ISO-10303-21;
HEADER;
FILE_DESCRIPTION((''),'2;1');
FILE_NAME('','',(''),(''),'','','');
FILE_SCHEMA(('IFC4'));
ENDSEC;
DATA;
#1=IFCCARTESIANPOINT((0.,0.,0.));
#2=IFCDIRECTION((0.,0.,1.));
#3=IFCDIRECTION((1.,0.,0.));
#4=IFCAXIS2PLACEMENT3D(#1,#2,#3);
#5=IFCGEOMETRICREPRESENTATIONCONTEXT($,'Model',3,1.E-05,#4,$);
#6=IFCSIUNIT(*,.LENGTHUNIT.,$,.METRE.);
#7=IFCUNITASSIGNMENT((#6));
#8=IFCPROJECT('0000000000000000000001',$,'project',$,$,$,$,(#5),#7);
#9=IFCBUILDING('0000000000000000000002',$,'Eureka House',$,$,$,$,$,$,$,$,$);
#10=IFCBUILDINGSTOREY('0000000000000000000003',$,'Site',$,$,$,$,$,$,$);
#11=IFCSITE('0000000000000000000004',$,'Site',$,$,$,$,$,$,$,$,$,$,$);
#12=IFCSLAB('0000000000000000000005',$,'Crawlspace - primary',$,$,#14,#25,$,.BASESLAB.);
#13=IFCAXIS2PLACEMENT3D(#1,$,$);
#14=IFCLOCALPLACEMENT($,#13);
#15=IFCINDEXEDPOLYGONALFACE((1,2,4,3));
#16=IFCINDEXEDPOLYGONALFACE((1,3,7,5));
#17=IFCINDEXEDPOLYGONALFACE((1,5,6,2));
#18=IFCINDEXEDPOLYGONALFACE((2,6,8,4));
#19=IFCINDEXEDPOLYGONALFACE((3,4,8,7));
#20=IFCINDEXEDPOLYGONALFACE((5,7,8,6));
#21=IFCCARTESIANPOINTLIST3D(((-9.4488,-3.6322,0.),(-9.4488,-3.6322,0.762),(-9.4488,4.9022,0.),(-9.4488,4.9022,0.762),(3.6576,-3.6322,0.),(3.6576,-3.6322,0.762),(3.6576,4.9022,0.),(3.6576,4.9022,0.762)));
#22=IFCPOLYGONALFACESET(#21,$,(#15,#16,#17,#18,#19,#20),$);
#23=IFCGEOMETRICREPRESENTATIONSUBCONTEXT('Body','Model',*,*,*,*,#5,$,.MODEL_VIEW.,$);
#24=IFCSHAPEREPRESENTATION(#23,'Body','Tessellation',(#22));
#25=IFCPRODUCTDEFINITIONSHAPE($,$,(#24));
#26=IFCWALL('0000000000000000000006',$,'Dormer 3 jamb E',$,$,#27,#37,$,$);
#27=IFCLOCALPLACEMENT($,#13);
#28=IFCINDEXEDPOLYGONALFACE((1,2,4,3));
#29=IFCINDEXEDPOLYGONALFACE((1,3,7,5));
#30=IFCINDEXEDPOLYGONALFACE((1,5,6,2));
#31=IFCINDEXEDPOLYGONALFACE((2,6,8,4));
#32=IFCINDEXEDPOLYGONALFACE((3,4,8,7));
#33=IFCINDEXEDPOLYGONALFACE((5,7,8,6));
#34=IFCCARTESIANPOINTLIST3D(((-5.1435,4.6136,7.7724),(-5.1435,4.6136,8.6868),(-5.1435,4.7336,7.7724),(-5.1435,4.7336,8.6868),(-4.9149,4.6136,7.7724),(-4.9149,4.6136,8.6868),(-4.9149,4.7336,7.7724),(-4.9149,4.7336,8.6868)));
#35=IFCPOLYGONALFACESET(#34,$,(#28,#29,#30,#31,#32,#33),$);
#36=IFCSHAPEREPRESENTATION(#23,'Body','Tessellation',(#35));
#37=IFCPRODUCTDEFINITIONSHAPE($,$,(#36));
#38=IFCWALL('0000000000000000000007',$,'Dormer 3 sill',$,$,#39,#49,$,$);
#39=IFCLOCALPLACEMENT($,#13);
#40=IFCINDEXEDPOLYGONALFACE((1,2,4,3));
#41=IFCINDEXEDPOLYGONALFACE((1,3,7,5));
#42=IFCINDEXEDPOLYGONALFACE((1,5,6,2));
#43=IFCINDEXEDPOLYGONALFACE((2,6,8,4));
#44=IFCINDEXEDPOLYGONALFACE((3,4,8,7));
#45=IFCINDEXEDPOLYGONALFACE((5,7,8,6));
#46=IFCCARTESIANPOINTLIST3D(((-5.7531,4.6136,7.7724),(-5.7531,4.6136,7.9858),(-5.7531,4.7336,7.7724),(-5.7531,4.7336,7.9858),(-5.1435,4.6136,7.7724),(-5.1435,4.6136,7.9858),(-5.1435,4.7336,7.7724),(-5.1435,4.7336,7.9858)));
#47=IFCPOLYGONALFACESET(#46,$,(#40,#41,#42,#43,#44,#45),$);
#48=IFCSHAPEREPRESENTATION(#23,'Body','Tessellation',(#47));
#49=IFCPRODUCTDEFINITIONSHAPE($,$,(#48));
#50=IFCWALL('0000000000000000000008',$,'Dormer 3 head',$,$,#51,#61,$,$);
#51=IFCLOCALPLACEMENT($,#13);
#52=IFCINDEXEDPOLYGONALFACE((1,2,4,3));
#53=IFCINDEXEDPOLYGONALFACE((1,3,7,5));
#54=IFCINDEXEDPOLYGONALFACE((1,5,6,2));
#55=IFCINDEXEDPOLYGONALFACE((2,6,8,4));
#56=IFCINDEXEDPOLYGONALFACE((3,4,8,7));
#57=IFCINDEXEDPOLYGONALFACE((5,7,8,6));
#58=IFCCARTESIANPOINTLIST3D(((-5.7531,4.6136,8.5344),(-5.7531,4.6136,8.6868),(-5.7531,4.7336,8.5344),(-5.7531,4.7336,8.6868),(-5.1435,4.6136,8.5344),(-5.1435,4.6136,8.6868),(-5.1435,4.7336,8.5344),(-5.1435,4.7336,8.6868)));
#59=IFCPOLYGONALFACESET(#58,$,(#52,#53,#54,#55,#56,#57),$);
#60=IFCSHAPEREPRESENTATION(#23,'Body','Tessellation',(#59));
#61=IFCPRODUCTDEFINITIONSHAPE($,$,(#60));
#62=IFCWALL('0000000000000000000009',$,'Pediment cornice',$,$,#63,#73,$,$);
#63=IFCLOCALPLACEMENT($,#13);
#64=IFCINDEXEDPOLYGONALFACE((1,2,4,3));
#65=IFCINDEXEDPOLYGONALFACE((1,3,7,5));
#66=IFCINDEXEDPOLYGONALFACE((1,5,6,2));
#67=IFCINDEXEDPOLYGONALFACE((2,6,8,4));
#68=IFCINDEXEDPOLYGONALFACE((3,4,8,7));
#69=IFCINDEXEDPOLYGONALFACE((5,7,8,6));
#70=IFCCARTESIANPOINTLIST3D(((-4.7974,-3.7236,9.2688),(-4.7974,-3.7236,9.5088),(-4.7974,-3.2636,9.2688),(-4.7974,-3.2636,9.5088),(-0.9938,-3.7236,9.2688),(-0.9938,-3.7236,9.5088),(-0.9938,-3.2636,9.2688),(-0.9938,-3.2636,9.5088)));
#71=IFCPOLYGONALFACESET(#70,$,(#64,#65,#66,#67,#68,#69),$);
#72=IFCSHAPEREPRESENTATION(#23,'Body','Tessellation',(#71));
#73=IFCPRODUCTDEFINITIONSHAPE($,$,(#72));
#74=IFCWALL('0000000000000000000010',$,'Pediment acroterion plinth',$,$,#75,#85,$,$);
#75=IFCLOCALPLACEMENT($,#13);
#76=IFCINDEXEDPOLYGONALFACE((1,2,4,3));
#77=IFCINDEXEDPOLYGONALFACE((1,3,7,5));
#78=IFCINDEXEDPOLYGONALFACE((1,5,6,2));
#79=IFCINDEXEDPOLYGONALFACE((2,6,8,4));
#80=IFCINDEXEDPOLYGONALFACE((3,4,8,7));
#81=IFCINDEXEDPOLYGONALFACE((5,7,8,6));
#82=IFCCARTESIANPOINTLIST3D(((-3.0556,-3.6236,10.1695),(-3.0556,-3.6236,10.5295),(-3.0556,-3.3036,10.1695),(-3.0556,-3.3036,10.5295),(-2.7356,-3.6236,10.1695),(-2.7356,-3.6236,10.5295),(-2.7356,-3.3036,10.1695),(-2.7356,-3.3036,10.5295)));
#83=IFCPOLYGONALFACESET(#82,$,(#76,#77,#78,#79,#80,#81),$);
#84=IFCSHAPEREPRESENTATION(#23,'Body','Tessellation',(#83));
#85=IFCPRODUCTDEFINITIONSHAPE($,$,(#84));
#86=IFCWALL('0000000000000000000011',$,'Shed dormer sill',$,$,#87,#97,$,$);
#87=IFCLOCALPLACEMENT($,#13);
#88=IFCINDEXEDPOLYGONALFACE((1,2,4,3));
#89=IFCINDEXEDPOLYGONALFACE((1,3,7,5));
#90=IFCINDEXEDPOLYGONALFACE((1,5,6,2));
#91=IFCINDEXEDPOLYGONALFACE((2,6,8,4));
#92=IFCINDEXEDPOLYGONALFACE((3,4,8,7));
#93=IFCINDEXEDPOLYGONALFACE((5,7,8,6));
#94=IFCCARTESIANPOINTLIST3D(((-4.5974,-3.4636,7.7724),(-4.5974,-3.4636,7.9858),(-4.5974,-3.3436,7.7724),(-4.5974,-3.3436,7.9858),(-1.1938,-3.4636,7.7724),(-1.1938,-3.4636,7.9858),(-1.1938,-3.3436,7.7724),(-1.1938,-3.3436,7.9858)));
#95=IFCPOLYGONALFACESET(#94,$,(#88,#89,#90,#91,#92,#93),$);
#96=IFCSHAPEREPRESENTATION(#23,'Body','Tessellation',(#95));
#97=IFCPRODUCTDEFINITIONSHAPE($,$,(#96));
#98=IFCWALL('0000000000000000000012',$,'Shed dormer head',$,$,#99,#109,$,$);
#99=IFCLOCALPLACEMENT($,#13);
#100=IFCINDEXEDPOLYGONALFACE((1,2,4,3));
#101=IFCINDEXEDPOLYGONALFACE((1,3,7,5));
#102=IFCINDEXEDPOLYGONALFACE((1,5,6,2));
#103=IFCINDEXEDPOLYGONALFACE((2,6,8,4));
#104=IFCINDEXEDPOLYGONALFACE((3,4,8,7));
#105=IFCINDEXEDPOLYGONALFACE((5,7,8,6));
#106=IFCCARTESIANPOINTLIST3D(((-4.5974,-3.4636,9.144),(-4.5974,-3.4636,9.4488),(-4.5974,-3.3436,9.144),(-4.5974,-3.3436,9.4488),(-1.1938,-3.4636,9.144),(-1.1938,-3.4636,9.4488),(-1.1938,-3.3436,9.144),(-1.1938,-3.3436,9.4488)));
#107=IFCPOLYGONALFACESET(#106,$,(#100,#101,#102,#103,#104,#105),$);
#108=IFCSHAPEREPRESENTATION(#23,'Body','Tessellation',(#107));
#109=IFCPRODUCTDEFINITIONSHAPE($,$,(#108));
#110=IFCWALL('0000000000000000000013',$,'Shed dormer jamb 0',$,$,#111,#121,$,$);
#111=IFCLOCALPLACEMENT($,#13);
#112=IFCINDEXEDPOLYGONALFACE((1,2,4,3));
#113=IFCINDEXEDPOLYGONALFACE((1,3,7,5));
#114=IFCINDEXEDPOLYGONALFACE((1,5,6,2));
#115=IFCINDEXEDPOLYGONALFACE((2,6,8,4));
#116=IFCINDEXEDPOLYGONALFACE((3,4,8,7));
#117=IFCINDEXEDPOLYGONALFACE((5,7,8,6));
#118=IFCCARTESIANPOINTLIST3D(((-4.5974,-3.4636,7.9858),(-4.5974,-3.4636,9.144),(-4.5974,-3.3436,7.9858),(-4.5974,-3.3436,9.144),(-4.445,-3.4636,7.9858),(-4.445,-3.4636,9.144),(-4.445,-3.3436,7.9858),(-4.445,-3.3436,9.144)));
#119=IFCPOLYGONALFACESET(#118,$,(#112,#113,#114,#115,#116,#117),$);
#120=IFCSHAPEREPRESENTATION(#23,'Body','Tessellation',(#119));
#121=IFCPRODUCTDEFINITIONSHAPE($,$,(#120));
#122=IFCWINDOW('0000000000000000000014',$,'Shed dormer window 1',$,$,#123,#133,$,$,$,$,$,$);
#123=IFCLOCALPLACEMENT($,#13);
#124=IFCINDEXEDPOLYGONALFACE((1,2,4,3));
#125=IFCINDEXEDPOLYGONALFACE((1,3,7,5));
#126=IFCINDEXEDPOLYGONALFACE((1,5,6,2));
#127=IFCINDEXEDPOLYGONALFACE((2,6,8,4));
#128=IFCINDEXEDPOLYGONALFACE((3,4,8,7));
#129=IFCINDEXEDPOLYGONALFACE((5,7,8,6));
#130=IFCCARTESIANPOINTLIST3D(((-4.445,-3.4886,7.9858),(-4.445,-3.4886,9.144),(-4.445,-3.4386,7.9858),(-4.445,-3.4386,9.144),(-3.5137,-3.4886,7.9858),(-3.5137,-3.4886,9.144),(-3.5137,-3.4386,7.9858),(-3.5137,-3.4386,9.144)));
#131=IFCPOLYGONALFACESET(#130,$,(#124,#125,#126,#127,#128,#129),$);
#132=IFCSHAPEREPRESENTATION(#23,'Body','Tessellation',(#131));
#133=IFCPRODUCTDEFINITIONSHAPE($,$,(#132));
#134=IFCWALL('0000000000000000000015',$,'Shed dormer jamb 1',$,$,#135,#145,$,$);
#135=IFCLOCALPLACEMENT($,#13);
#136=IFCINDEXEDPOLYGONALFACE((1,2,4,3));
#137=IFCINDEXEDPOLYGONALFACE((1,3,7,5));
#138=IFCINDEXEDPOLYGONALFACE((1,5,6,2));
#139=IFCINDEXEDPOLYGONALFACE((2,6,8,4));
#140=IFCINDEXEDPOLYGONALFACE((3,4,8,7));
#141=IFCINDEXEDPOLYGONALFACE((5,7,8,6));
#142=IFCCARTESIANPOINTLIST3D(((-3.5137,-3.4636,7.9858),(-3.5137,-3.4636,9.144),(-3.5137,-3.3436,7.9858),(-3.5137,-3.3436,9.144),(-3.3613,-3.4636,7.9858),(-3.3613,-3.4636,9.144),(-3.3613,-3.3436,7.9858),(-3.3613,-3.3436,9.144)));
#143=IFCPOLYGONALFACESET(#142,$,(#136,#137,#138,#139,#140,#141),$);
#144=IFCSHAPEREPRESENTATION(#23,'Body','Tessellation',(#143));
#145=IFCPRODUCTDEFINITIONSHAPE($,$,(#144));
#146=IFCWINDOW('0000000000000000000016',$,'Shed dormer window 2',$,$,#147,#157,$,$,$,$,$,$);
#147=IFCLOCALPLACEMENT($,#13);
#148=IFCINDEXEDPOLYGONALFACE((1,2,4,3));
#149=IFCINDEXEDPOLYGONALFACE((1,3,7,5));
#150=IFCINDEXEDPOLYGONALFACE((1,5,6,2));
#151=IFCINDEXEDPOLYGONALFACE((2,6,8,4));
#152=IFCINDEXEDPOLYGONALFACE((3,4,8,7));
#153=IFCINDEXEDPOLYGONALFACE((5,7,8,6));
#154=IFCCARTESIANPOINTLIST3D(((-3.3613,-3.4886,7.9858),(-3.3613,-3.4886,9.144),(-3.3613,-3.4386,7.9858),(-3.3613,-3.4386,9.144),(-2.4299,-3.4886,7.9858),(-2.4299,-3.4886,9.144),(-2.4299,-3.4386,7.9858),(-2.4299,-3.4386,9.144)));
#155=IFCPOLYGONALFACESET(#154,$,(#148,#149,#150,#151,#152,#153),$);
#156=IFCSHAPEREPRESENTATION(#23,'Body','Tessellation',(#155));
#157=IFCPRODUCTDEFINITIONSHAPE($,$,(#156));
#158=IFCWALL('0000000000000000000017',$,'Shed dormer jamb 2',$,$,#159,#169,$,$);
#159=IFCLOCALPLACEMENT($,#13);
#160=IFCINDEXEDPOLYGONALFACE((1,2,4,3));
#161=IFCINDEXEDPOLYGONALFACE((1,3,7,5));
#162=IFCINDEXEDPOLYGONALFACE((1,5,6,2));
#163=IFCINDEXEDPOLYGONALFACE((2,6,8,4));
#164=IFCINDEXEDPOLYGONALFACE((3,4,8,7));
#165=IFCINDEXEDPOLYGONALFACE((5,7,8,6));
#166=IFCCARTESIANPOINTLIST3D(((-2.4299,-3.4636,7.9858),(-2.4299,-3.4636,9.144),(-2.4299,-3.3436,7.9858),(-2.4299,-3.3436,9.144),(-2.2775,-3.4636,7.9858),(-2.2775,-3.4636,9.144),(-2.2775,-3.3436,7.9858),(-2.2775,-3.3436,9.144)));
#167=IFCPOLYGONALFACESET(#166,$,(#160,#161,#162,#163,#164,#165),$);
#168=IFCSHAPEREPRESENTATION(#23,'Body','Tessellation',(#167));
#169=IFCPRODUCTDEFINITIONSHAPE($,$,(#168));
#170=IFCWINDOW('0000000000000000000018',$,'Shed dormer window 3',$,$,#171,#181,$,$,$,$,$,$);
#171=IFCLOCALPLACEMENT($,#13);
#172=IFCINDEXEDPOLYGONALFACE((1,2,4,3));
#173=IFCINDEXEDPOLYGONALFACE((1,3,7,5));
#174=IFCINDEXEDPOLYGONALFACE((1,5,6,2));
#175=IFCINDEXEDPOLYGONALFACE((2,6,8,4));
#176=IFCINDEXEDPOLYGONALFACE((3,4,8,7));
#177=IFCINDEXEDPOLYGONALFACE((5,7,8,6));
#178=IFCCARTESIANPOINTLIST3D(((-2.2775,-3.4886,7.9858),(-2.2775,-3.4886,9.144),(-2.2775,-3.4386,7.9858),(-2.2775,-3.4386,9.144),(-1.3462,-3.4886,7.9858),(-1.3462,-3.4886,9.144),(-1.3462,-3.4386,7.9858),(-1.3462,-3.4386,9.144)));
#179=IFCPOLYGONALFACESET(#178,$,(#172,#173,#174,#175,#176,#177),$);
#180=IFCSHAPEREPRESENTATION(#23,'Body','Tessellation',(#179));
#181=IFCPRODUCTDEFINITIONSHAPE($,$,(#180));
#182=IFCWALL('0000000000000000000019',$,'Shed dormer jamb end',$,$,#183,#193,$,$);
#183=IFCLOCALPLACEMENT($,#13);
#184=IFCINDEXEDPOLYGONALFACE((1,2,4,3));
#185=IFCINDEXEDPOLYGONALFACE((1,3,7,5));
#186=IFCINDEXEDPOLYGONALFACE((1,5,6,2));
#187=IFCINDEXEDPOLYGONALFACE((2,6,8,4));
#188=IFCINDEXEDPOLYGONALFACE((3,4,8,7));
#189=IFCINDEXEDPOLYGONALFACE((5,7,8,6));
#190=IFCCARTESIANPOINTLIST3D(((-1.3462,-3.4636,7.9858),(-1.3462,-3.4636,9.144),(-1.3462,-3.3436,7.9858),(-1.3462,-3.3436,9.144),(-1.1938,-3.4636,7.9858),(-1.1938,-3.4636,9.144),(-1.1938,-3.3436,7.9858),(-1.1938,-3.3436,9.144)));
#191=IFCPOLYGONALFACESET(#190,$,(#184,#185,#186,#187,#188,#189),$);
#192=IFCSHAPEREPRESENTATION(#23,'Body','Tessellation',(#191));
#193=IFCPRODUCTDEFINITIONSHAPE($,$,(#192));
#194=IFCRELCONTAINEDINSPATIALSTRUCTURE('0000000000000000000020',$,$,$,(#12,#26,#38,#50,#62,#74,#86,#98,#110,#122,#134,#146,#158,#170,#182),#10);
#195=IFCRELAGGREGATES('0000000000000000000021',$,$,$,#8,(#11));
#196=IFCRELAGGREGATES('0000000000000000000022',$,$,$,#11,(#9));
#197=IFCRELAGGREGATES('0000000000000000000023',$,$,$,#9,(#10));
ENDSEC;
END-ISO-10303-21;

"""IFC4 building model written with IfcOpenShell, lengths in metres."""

from ifc_helpers import new_model, si_unit, frame, origin, origin_with_axes, origin_2d, place, context, subcontext, project, spatial, rectangle, extrude, element, save


model = new_model("IFC4")

# Units and contexts
model_context = context("Model", 3, precision=1e-05, world=origin_with_axes())
body_context = subcontext(model_context, "Body", "Model", "MODEL_VIEW")
ifc_project = project(units=[si_unit("LENGTHUNIT", "METRE")], contexts=[model_context])

# Site, building, storey
site = spatial("IfcSite", under=ifc_project, Name="Site")
building = spatial("IfcBuilding", under=site, Name="Eureka House")
storey = spatial("IfcBuildingStorey", under=building, Name="Site")

# Slab
slab_placement = place(None, frame((-2.8956, 0.635, 0.0), z_axis=(0.0, 0.0, 1.0), x_axis=(1.0, 0.0, 0.0)))
element("IfcSlab", 1, at=slab_placement, inside=storey, Name="Crawlspace - primary", PredefinedType="BASESLAB", context=body_context, shape_type="SweptSolid", body=[
    extrude(rectangle(XDim=13.1064, YDim=8.5344, at=origin_2d()), origin(), (0.0, 0.0, 1.0), 0.762),
])

# Walls
wall_1_placement = place(None, frame((-5.0292, 4.6736, 7.7724), z_axis=(0.0, 0.0, 1.0), x_axis=(1.0, 0.0, 0.0)))
element("IfcWall", 2, at=wall_1_placement, inside=storey, Name="Dormer 3 jamb E", context=body_context, shape_type="SweptSolid", body=[
    extrude(rectangle(XDim=0.2286, YDim=0.12, at=origin_2d()), origin(), (0.0, 0.0, 1.0), 0.9144),
])
wall_2_placement = place(None, frame((-5.4483, 4.6736, 7.7724), z_axis=(0.0, 0.0, 1.0), x_axis=(1.0, 0.0, 0.0)))
element("IfcWall", 3, at=wall_2_placement, inside=storey, Name="Dormer 3 sill", context=body_context, shape_type="SweptSolid", body=[
    extrude(rectangle(XDim=0.6096, YDim=0.12, at=origin_2d()), origin(), (0.0, 0.0, 1.0), 0.2134),
])
wall_3_placement = place(None, frame((-5.4483, 4.6736, 8.5344), z_axis=(0.0, 0.0, 1.0), x_axis=(1.0, 0.0, 0.0)))
element("IfcWall", 4, at=wall_3_placement, inside=storey, Name="Dormer 3 head", context=body_context, shape_type="SweptSolid", body=[
    extrude(rectangle(XDim=0.6096, YDim=0.12, at=origin_2d()), origin(), (0.0, 0.0, 1.0), 0.1524),
])
wall_4_placement = place(None, frame((-2.8956, -3.4936, 9.2688), z_axis=(0.0, 0.0, 1.0), x_axis=(1.0, 0.0, 0.0)))
element("IfcWall", 5, at=wall_4_placement, inside=storey, Name="Pediment cornice", context=body_context, shape_type="SweptSolid", body=[
    extrude(rectangle(XDim=3.8036, YDim=0.46, at=origin_2d()), origin(), (0.0, 0.0, 1.0), 0.24),
])
wall_5_placement = place(None, frame((-2.8956, -3.4636, 10.1695), z_axis=(0.0, 0.0, 1.0), x_axis=(1.0, 0.0, 0.0)))
element("IfcWall", 6, at=wall_5_placement, inside=storey, Name="Pediment acroterion plinth", context=body_context, shape_type="SweptSolid", body=[
    extrude(rectangle(XDim=0.32, YDim=0.32, at=origin_2d()), origin(), (0.0, 0.0, 1.0), 0.36),
])
wall_6_placement = place(None, frame((-2.8956, -3.4036, 7.7724), z_axis=(0.0, 0.0, 1.0), x_axis=(1.0, 0.0, 0.0)))
element("IfcWall", 7, at=wall_6_placement, inside=storey, Name="Shed dormer sill", context=body_context, shape_type="SweptSolid", body=[
    extrude(rectangle(XDim=3.4036, YDim=0.12, at=origin_2d()), origin(), (0.0, 0.0, 1.0), 0.2134),
])
wall_7_placement = place(None, frame((-2.8956, -3.4036, 9.144), z_axis=(0.0, 0.0, 1.0), x_axis=(1.0, 0.0, 0.0)))
element("IfcWall", 8, at=wall_7_placement, inside=storey, Name="Shed dormer head", context=body_context, shape_type="SweptSolid", body=[
    extrude(rectangle(XDim=3.4036, YDim=0.12, at=origin_2d()), origin(), (0.0, 0.0, 1.0), 0.3048),
])
wall_8_placement = place(None, frame((-4.5212, -3.4036, 7.9858), z_axis=(0.0, 0.0, 1.0), x_axis=(1.0, 0.0, 0.0)))
element("IfcWall", 9, at=wall_8_placement, inside=storey, Name="Shed dormer jamb 0", context=body_context, shape_type="SweptSolid", body=[
    extrude(rectangle(XDim=0.1524, YDim=0.12, at=origin_2d()), origin(), (0.0, 0.0, 1.0), 1.1582),
])

# Window
window_1_placement = place(None, frame((-3.9793, -3.4636, 7.9858), z_axis=(0.0, 0.0, 1.0), x_axis=(1.0, 0.0, 0.0)))
element("IfcWindow", 10, at=window_1_placement, inside=storey, Name="Shed dormer window 1", context=body_context, shape_type="SweptSolid", body=[
    extrude(rectangle(XDim=0.9313, YDim=0.05, at=origin_2d()), origin(), (0.0, 0.0, 1.0), 1.1582),
])

# Wall
wall_9_placement = place(None, frame((-3.4375, -3.4036, 7.9858), z_axis=(0.0, 0.0, 1.0), x_axis=(1.0, 0.0, 0.0)))
element("IfcWall", 11, at=wall_9_placement, inside=storey, Name="Shed dormer jamb 1", context=body_context, shape_type="SweptSolid", body=[
    extrude(rectangle(XDim=0.1524, YDim=0.12, at=origin_2d()), origin(), (0.0, 0.0, 1.0), 1.1582),
])

# Window
window_2_placement = place(None, frame((-2.8956, -3.4636, 7.9858), z_axis=(0.0, 0.0, 1.0), x_axis=(1.0, 0.0, 0.0)))
element("IfcWindow", 12, at=window_2_placement, inside=storey, Name="Shed dormer window 2", context=body_context, shape_type="SweptSolid", body=[
    extrude(rectangle(XDim=0.9313, YDim=0.05, at=origin_2d()), origin(), (0.0, 0.0, 1.0), 1.1582),
])

# Wall
wall_10_placement = place(None, frame((-2.3537, -3.4036, 7.9858), z_axis=(0.0, 0.0, 1.0), x_axis=(1.0, 0.0, 0.0)))
element("IfcWall", 13, at=wall_10_placement, inside=storey, Name="Shed dormer jamb 2", context=body_context, shape_type="SweptSolid", body=[
    extrude(rectangle(XDim=0.1524, YDim=0.12, at=origin_2d()), origin(), (0.0, 0.0, 1.0), 1.1582),
])

# Window
window_3_placement = place(None, frame((-1.8119, -3.4636, 7.9858), z_axis=(0.0, 0.0, 1.0), x_axis=(1.0, 0.0, 0.0)))
element("IfcWindow", 14, at=window_3_placement, inside=storey, Name="Shed dormer window 3", context=body_context, shape_type="SweptSolid", body=[
    extrude(rectangle(XDim=0.9313, YDim=0.05, at=origin_2d()), origin(), (0.0, 0.0, 1.0), 1.1582),
])

# Wall
wall_11_placement = place(None, frame((-1.27, -3.4036, 7.9858), z_axis=(0.0, 0.0, 1.0), x_axis=(1.0, 0.0, 0.0)))
element("IfcWall", 15, at=wall_11_placement, inside=storey, Name="Shed dormer jamb end", context=body_context, shape_type="SweptSolid", body=[
    extrude(rectangle(XDim=0.1524, YDim=0.12, at=origin_2d()), origin(), (0.0, 0.0, 1.0), 1.1582),
])

save(model, "model.ifc")
